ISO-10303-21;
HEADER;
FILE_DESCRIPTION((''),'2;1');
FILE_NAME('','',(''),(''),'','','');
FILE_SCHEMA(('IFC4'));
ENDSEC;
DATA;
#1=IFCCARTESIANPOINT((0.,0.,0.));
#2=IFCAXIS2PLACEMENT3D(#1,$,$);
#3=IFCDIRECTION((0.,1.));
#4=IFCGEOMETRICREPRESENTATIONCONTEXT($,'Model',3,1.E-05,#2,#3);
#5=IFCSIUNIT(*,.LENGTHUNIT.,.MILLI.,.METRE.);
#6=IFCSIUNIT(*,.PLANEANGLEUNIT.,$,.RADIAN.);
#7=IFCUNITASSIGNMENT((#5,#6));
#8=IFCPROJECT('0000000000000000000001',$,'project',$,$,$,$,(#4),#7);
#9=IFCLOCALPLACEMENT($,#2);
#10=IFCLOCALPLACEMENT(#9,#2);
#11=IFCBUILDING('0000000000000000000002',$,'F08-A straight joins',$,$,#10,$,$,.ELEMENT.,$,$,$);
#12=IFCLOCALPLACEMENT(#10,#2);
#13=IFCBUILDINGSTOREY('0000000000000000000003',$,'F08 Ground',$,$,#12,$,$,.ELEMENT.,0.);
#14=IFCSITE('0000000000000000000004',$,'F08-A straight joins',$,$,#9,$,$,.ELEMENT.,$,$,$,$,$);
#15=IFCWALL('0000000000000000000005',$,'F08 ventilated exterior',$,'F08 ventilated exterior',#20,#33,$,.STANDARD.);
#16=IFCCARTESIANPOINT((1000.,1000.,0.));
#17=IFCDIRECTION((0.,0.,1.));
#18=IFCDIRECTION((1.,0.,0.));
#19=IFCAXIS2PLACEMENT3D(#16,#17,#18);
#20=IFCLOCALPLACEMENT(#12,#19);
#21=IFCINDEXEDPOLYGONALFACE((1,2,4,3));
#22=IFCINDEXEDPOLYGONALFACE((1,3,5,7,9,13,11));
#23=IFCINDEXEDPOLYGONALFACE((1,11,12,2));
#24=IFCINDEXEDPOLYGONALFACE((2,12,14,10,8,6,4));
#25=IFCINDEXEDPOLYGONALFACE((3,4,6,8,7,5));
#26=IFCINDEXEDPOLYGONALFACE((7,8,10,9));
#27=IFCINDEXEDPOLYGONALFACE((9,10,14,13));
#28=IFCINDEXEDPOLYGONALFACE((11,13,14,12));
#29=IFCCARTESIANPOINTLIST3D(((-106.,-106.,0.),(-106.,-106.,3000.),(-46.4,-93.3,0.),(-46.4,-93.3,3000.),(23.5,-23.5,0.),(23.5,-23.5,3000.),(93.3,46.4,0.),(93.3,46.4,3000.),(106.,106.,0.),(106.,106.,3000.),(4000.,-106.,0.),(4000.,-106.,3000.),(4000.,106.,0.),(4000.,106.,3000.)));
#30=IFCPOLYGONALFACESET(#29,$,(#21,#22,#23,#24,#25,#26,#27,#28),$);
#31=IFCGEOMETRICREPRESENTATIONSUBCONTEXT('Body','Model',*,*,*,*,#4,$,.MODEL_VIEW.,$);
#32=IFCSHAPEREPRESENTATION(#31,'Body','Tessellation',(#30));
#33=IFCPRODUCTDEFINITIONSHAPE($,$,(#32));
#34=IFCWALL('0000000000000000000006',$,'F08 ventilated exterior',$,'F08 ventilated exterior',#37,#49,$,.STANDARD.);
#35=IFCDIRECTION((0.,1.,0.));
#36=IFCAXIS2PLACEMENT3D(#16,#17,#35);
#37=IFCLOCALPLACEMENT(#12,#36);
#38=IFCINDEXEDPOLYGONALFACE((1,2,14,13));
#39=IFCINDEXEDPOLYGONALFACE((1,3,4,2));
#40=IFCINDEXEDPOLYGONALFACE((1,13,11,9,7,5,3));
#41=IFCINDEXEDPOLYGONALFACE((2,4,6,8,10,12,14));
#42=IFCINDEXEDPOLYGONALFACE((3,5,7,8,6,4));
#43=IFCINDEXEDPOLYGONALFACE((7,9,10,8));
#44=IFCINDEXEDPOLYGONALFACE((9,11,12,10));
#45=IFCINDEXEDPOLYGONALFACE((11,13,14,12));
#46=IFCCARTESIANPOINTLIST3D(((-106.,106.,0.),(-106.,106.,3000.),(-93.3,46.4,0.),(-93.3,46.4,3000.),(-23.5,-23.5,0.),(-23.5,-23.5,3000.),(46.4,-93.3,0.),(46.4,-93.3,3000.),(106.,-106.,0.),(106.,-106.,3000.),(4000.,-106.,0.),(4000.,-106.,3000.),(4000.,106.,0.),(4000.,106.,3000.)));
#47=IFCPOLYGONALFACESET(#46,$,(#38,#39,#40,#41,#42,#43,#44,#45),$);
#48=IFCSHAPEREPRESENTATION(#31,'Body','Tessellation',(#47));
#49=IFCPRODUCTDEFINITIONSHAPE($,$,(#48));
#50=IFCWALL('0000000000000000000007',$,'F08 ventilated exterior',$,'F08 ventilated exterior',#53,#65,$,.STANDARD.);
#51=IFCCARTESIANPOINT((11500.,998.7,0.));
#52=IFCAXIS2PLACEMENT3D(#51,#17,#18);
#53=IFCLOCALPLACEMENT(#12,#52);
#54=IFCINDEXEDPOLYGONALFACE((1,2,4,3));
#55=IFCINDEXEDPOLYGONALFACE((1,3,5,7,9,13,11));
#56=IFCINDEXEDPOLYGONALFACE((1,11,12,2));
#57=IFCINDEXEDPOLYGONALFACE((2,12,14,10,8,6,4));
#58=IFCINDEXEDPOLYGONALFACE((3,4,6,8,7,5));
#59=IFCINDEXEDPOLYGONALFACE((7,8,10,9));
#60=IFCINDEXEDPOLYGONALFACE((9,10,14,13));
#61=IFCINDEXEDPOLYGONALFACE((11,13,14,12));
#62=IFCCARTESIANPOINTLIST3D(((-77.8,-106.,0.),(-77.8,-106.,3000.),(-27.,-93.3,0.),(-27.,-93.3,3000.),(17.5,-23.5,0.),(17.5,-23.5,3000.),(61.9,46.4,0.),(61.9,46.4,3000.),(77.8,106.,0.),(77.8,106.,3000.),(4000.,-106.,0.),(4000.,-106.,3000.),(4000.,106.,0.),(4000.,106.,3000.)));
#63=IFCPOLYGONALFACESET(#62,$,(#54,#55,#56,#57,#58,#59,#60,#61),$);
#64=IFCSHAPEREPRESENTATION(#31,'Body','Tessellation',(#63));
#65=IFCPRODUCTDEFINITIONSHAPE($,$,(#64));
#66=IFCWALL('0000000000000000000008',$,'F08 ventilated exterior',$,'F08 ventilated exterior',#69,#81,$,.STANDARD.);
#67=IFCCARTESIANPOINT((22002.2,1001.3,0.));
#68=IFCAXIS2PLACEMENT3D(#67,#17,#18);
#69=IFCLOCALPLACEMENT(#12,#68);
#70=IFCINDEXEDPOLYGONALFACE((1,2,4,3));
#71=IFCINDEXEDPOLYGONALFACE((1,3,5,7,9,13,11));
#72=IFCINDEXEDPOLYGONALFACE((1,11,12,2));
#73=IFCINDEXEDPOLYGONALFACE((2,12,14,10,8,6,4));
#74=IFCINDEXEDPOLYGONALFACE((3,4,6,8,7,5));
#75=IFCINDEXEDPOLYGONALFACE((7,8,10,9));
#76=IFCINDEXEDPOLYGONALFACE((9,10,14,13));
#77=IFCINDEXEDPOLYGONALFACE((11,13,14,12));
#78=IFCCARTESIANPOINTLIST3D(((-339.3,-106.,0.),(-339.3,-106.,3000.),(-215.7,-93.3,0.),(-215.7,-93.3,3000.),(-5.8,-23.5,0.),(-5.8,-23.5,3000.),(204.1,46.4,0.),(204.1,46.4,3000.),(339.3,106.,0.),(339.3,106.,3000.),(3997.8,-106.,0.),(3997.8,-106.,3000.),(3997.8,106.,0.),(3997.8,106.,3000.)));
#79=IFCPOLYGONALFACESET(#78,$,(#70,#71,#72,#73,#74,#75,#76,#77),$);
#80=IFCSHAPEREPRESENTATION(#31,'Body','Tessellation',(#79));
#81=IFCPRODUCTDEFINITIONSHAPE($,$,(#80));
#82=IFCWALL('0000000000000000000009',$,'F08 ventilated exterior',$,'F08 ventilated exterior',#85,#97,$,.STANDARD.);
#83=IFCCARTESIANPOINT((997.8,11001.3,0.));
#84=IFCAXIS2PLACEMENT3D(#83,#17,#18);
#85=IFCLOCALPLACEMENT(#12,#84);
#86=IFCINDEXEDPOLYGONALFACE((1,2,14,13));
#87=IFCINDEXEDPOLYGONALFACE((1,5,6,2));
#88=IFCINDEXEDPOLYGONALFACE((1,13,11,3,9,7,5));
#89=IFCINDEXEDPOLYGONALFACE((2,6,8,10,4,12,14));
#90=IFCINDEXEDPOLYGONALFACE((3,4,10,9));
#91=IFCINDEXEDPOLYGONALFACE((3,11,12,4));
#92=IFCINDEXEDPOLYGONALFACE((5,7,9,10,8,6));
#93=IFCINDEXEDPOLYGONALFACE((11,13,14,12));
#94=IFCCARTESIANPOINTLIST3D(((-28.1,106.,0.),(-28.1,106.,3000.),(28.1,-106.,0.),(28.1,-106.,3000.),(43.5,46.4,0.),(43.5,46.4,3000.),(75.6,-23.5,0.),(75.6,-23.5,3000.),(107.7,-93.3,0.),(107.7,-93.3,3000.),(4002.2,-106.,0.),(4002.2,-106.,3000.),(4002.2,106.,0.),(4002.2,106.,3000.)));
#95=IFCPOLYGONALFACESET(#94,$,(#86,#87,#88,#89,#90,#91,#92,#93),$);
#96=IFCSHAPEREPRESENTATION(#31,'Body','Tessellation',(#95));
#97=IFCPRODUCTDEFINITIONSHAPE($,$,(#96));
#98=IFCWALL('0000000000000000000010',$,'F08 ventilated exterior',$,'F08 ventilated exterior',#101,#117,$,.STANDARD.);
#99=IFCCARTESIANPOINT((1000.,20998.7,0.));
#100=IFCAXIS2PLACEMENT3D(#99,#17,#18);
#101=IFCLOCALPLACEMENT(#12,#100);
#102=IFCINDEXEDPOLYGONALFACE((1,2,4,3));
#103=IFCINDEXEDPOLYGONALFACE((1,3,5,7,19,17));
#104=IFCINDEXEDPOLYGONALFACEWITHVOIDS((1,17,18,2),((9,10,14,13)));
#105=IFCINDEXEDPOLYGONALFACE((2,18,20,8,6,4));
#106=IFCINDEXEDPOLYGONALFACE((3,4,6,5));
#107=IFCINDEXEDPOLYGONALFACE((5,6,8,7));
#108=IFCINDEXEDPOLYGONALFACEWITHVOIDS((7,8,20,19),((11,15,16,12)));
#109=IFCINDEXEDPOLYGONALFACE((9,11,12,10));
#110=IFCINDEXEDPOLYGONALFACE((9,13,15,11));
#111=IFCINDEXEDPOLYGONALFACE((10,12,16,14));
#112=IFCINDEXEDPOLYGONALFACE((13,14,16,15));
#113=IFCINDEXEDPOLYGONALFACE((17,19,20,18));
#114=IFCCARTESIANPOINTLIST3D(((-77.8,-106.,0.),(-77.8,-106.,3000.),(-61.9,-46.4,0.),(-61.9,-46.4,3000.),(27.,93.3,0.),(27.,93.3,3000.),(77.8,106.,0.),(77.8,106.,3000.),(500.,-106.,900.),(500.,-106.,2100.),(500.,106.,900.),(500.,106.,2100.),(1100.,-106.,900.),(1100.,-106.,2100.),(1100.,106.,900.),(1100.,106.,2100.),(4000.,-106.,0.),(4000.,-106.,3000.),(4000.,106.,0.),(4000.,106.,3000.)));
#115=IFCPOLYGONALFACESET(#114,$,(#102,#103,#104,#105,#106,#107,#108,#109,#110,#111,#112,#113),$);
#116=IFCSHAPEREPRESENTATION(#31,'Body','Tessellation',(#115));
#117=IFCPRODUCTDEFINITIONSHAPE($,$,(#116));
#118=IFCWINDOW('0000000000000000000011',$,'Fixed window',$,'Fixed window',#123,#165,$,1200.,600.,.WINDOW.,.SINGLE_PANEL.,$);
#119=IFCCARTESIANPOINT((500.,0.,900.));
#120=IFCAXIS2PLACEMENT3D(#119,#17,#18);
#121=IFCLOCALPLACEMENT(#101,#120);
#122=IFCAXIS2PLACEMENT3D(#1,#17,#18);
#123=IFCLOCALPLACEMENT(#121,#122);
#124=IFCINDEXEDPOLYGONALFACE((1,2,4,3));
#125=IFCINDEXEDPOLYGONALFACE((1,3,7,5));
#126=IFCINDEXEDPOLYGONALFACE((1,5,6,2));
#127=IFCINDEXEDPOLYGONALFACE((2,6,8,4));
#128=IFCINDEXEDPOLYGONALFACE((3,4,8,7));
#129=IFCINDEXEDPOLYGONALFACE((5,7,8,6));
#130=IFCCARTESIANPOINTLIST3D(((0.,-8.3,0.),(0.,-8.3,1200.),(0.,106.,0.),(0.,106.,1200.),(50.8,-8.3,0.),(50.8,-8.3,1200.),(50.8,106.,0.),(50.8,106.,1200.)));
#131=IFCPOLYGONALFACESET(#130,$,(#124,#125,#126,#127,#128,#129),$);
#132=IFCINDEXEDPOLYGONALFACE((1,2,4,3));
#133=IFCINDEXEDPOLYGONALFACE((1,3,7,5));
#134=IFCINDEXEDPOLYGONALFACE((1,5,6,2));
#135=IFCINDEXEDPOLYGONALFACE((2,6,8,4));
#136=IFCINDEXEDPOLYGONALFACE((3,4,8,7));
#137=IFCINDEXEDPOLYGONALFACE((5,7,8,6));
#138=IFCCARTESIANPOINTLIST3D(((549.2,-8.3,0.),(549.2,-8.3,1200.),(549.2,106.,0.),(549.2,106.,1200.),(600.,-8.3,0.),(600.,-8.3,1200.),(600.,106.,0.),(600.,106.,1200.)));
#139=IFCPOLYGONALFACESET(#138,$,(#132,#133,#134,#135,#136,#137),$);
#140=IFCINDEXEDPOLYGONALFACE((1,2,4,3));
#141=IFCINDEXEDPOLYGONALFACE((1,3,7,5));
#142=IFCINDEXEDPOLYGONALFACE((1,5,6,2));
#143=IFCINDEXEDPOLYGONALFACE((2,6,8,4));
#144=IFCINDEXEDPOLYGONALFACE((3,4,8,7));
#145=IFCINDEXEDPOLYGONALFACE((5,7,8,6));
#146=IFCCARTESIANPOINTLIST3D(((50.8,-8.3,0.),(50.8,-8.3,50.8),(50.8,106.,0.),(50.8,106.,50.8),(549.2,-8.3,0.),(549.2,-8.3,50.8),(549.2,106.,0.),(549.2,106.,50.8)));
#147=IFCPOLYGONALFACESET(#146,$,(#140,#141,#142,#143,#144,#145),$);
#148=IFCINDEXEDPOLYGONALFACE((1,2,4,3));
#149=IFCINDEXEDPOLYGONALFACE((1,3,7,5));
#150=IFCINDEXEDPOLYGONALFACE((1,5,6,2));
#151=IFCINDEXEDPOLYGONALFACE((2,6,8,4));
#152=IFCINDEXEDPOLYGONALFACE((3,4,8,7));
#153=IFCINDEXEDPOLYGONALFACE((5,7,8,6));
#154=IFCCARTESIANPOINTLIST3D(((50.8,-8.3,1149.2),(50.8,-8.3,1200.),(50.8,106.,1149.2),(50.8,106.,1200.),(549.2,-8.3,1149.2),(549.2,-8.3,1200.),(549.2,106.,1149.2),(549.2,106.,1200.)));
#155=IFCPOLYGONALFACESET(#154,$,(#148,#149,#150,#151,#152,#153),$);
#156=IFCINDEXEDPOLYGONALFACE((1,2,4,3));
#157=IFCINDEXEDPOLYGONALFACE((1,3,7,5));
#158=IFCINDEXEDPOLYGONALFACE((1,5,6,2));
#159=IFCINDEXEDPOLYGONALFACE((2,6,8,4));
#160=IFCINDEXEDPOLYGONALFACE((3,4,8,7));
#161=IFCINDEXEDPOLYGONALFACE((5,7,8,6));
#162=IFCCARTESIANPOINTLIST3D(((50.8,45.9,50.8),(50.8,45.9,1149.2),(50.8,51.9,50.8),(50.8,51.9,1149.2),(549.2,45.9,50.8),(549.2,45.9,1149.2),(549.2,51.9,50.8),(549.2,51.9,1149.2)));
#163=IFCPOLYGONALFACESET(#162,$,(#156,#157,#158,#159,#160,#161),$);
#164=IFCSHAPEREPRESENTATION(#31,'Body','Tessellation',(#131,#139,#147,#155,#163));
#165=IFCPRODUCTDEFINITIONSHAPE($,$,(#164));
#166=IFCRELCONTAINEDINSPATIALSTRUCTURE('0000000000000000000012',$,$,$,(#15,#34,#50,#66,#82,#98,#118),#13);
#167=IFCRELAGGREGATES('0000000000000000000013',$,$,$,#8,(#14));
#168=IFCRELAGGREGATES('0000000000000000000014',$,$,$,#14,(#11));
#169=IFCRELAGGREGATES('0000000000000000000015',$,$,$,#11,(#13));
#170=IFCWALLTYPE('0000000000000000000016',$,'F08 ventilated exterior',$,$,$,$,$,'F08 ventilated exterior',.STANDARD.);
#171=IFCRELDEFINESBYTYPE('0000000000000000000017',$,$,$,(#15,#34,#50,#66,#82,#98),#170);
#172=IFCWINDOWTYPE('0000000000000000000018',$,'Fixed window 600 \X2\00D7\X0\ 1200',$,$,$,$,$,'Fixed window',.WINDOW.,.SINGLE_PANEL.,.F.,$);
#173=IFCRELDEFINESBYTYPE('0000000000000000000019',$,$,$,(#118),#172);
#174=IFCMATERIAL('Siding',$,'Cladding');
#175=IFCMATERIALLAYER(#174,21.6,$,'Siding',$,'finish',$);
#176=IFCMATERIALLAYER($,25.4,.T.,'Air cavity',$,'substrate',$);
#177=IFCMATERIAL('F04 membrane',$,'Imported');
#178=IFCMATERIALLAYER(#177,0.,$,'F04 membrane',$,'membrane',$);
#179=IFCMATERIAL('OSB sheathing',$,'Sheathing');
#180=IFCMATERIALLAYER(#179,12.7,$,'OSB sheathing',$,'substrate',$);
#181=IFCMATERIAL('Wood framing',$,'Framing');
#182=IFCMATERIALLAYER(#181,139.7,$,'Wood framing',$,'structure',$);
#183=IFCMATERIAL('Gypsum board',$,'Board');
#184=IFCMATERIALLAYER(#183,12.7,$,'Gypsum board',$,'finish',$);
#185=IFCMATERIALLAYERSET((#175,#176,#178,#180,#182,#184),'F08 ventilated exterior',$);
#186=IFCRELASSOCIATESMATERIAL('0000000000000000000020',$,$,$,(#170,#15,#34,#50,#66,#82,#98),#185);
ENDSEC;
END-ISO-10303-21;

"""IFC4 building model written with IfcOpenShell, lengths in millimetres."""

from ifc_helpers import new_model, si_unit, direction, frame, origin, origin_with_axes, place, context, subcontext, project, spatial, polyline, outline, extrude, material, layer, layer_set, layer_usage, type_object, element, fill, save


model = new_model("IFC4")

# Units and contexts
model_context = context("Model", 3, precision=1e-05, world=origin(), true_north=direction((0.0, 1.0)))
body_context = subcontext(model_context, "Body", "Model", "MODEL_VIEW")
ifc_project = project(units=[si_unit("LENGTHUNIT", "METRE", prefix="MILLI"), si_unit("PLANEANGLEUNIT", "RADIAN")], contexts=[model_context])

# Site, building, storey
site_placement = place(None, origin())
site = spatial("IfcSite", under=ifc_project, at=site_placement, Name="F08-A straight joins", CompositionType="ELEMENT")
building_placement = place(site_placement, origin())
building = spatial("IfcBuilding", under=site, at=building_placement, Name="F08-A straight joins", CompositionType="ELEMENT")
storey_placement = place(building_placement, origin())
storey = spatial("IfcBuildingStorey", under=building, at=storey_placement, Name="F08 Ground", CompositionType="ELEMENT", Elevation=0.0)

# Walls
ifc_material_1 = material(Name="Siding", Category="Cladding")
ifc_layer_1 = layer(ifc_material_1, 21.6, Name="Siding", Category="finish")
ifc_layer_2 = layer(None, 25.4, ventilated=True, Name="Air cavity", Category="substrate")
ifc_material_2 = material(Name="F04 membrane", Category="Imported")
ifc_layer_3 = layer(ifc_material_2, 0.0, Name="F04 membrane", Category="membrane")
ifc_material_3 = material(Name="OSB sheathing", Category="Sheathing")
ifc_layer_4 = layer(ifc_material_3, 12.7, Name="OSB sheathing", Category="substrate")
ifc_material_4 = material(Name="Wood framing", Category="Framing")
ifc_layer_5 = layer(ifc_material_4, 139.7, Name="Wood framing", Category="structure")
ifc_material_5 = material(Name="Gypsum board", Category="Board")
ifc_layer_6 = layer(ifc_material_5, 12.7, Name="Gypsum board", Category="finish")
ifc_layer_set_1 = layer_set([ifc_layer_1, ifc_layer_2, ifc_layer_3, ifc_layer_4, ifc_layer_5, ifc_layer_6], Name="F08 ventilated exterior")
ifc_layer_usage_1 = layer_usage(ifc_layer_set_1, "AXIS2", "NEGATIVE", 106.0)
wall_type_1 = type_object("IfcWallType", Name="F08 ventilated exterior", ElementType="F08 ventilated exterior", PredefinedType="STANDARD", material=ifc_layer_set_1)
wall_1_placement = place(storey_placement, frame((1000.0, 1000.0, 0.0), z_axis=(0.0, 0.0, 1.0), x_axis=(1.0, 0.0, 0.0)))
element("IfcWall", 1, at=wall_1_placement, inside=storey, type_object=wall_type_1, material=ifc_layer_usage_1, Name="F08 ventilated exterior", ObjectType="F08 ventilated exterior", PredefinedType="STANDARD", context=body_context, shape_type="SweptSolid", body=[
    extrude(outline(polyline([(-106.0, -106.0), (4000.0, -106.0), (4000.0, 106.0), (106.0, 106.0), (93.3, 46.4), (23.5, -23.5), (-46.4, -93.3), (-106.0, -106.0)])), origin(), (0.0, 0.0, 1.0), 3000.0),
])
ifc_layer_usage_2 = layer_usage(ifc_layer_set_1, "AXIS2", "NEGATIVE", 106.0)
wall_2_placement = place(storey_placement, frame((1000.0, 1000.0, 0.0), z_axis=(0.0, 0.0, 1.0), x_axis=(0.0, 1.0, 0.0)))
element("IfcWall", 2, at=wall_2_placement, inside=storey, type_object=wall_type_1, material=ifc_layer_usage_2, Name="F08 ventilated exterior", ObjectType="F08 ventilated exterior", PredefinedType="STANDARD", context=body_context, shape_type="SweptSolid", body=[
    extrude(outline(polyline([(106.0, -106.0), (4000.0, -106.0), (4000.0, 106.0), (-106.0, 106.0), (-93.3, 46.4), (-23.5, -23.5), (46.4, -93.3), (106.0, -106.0)])), origin(), (0.0, 0.0, 1.0), 3000.0),
])
ifc_layer_usage_3 = layer_usage(ifc_layer_set_1, "AXIS2", "NEGATIVE", 106.0)
wall_3_placement = place(storey_placement, frame((11500.0, 998.7, 0.0), z_axis=(0.0, 0.0, 1.0), x_axis=(1.0, 0.0, 0.0)))
element("IfcWall", 3, at=wall_3_placement, inside=storey, type_object=wall_type_1, material=ifc_layer_usage_3, Name="F08 ventilated exterior", ObjectType="F08 ventilated exterior", PredefinedType="STANDARD", context=body_context, shape_type="SweptSolid", body=[
    extrude(outline(polyline([(-77.8, -106.0), (4000.0, -106.0), (4000.0, 106.0), (77.8, 106.0), (61.9, 46.4), (17.5, -23.5), (-27.0, -93.3), (-77.8, -106.0)])), origin(), (0.0, 0.0, 1.0), 3000.0),
])
ifc_layer_usage_4 = layer_usage(ifc_layer_set_1, "AXIS2", "NEGATIVE", 106.0)
wall_4_placement = place(storey_placement, frame((22002.2, 1001.3, 0.0), z_axis=(0.0, 0.0, 1.0), x_axis=(1.0, 0.0, 0.0)))
element("IfcWall", 4, at=wall_4_placement, inside=storey, type_object=wall_type_1, material=ifc_layer_usage_4, Name="F08 ventilated exterior", ObjectType="F08 ventilated exterior", PredefinedType="STANDARD", context=body_context, shape_type="SweptSolid", body=[
    extrude(outline(polyline([(-339.3, -106.0), (3997.8, -106.0), (3997.8, 106.0), (339.3, 106.0), (204.1, 46.4), (-5.8, -23.5), (-215.7, -93.3), (-339.3, -106.0)])), origin(), (0.0, 0.0, 1.0), 3000.0),
])
ifc_layer_usage_5 = layer_usage(ifc_layer_set_1, "AXIS2", "NEGATIVE", 106.0)
wall_5_placement = place(storey_placement, frame((997.8, 11001.3, 0.0), z_axis=(0.0, 0.0, 1.0), x_axis=(1.0, 0.0, 0.0)))
element("IfcWall", 5, at=wall_5_placement, inside=storey, type_object=wall_type_1, material=ifc_layer_usage_5, Name="F08 ventilated exterior", ObjectType="F08 ventilated exterior", PredefinedType="STANDARD", context=body_context, shape_type="SweptSolid", body=[
    extrude(outline(polyline([(28.1, -106.0), (4002.2, -106.0), (4002.2, 106.0), (-28.1, 106.0), (43.5, 46.4), (75.6, -23.5), (107.7, -93.3), (28.1, -106.0)])), origin(), (0.0, 0.0, 1.0), 3000.0),
])

# Wall, opening, window
ifc_layer_usage_6 = layer_usage(ifc_layer_set_1, "AXIS2", "POSITIVE", -106.0)
wall_6_placement = place(storey_placement, frame((1000.0, 20998.7, 0.0), z_axis=(0.0, 0.0, 1.0), x_axis=(1.0, 0.0, 0.0)))
wall_6 = element("IfcWall", 6, at=wall_6_placement, inside=storey, type_object=wall_type_1, material=ifc_layer_usage_6, Name="F08 ventilated exterior", ObjectType="F08 ventilated exterior", PredefinedType="STANDARD", context=body_context, shape_type="SweptSolid", body=[
    extrude(outline(polyline([(-77.8, -106.0), (4000.0, -106.0), (4000.0, 106.0), (77.8, 106.0), (27.0, 93.3), (-17.5, 23.5), (-61.9, -46.4), (-77.8, -106.0)])), origin(), (0.0, 0.0, 1.0), 3000.0),
])
opening_placement = place(wall_6_placement, frame((500.0, 0.0, 900.0), z_axis=(0.0, 0.0, 1.0), x_axis=(1.0, 0.0, 0.0)))
opening = element("IfcOpeningElement", 7, at=opening_placement, cuts=wall_6, PredefinedType="OPENING", context=body_context, shape_type="SweptSolid", body=[
    extrude(outline(polyline([(0.0, -116.0), (600.0, -116.0), (600.0, 116.0), (0.0, 116.0), (0.0, -116.0)])), origin(), (0.0, 0.0, 1.0), 1200.0),
])
window_type = type_object("IfcWindowType", Name="Fixed window 600 × 1200", ElementType="Fixed window", ParameterTakesPrecedence=False, PartitioningType="SINGLE_PANEL", PredefinedType="WINDOW")
window_placement = place(opening_placement, origin_with_axes())
window = element("IfcWindow", 8, at=window_placement, inside=storey, type_object=window_type, Name="Fixed window", ObjectType="Fixed window", OverallHeight=1200.0, OverallWidth=600.0, PartitioningType="SINGLE_PANEL", PredefinedType="WINDOW", context=body_context, shape_type="SweptSolid", body=[
    extrude(outline(polyline([(0.0, -8.3), (50.8, -8.3), (50.8, 106.0), (0.0, 106.0), (0.0, -8.3)])), origin(), (0.0, 0.0, 1.0), 1200.0),
    extrude(outline(polyline([(549.2, -8.3), (600.0, -8.3), (600.0, 106.0), (549.2, 106.0), (549.2, -8.3)])), origin(), (0.0, 0.0, 1.0), 1200.0),
    extrude(outline(polyline([(50.8, -8.3), (549.2, -8.3), (549.2, 106.0), (50.8, 106.0), (50.8, -8.3)])), origin(), (0.0, 0.0, 1.0), 50.8),
    extrude(outline(polyline([(50.8, -8.3), (549.2, -8.3), (549.2, 106.0), (50.8, 106.0), (50.8, -8.3)])), frame((0.0, 0.0, 1149.2)), (0.0, 0.0, 1.0), 50.8),
    extrude(outline(polyline([(50.8, 45.9), (549.2, 45.9), (549.2, 51.9), (50.8, 51.9), (50.8, 45.9)])), frame((0.0, 0.0, 50.8)), (0.0, 0.0, 1.0), 1098.4),
])
fill(opening, window)

save(model, "model.ifc")
